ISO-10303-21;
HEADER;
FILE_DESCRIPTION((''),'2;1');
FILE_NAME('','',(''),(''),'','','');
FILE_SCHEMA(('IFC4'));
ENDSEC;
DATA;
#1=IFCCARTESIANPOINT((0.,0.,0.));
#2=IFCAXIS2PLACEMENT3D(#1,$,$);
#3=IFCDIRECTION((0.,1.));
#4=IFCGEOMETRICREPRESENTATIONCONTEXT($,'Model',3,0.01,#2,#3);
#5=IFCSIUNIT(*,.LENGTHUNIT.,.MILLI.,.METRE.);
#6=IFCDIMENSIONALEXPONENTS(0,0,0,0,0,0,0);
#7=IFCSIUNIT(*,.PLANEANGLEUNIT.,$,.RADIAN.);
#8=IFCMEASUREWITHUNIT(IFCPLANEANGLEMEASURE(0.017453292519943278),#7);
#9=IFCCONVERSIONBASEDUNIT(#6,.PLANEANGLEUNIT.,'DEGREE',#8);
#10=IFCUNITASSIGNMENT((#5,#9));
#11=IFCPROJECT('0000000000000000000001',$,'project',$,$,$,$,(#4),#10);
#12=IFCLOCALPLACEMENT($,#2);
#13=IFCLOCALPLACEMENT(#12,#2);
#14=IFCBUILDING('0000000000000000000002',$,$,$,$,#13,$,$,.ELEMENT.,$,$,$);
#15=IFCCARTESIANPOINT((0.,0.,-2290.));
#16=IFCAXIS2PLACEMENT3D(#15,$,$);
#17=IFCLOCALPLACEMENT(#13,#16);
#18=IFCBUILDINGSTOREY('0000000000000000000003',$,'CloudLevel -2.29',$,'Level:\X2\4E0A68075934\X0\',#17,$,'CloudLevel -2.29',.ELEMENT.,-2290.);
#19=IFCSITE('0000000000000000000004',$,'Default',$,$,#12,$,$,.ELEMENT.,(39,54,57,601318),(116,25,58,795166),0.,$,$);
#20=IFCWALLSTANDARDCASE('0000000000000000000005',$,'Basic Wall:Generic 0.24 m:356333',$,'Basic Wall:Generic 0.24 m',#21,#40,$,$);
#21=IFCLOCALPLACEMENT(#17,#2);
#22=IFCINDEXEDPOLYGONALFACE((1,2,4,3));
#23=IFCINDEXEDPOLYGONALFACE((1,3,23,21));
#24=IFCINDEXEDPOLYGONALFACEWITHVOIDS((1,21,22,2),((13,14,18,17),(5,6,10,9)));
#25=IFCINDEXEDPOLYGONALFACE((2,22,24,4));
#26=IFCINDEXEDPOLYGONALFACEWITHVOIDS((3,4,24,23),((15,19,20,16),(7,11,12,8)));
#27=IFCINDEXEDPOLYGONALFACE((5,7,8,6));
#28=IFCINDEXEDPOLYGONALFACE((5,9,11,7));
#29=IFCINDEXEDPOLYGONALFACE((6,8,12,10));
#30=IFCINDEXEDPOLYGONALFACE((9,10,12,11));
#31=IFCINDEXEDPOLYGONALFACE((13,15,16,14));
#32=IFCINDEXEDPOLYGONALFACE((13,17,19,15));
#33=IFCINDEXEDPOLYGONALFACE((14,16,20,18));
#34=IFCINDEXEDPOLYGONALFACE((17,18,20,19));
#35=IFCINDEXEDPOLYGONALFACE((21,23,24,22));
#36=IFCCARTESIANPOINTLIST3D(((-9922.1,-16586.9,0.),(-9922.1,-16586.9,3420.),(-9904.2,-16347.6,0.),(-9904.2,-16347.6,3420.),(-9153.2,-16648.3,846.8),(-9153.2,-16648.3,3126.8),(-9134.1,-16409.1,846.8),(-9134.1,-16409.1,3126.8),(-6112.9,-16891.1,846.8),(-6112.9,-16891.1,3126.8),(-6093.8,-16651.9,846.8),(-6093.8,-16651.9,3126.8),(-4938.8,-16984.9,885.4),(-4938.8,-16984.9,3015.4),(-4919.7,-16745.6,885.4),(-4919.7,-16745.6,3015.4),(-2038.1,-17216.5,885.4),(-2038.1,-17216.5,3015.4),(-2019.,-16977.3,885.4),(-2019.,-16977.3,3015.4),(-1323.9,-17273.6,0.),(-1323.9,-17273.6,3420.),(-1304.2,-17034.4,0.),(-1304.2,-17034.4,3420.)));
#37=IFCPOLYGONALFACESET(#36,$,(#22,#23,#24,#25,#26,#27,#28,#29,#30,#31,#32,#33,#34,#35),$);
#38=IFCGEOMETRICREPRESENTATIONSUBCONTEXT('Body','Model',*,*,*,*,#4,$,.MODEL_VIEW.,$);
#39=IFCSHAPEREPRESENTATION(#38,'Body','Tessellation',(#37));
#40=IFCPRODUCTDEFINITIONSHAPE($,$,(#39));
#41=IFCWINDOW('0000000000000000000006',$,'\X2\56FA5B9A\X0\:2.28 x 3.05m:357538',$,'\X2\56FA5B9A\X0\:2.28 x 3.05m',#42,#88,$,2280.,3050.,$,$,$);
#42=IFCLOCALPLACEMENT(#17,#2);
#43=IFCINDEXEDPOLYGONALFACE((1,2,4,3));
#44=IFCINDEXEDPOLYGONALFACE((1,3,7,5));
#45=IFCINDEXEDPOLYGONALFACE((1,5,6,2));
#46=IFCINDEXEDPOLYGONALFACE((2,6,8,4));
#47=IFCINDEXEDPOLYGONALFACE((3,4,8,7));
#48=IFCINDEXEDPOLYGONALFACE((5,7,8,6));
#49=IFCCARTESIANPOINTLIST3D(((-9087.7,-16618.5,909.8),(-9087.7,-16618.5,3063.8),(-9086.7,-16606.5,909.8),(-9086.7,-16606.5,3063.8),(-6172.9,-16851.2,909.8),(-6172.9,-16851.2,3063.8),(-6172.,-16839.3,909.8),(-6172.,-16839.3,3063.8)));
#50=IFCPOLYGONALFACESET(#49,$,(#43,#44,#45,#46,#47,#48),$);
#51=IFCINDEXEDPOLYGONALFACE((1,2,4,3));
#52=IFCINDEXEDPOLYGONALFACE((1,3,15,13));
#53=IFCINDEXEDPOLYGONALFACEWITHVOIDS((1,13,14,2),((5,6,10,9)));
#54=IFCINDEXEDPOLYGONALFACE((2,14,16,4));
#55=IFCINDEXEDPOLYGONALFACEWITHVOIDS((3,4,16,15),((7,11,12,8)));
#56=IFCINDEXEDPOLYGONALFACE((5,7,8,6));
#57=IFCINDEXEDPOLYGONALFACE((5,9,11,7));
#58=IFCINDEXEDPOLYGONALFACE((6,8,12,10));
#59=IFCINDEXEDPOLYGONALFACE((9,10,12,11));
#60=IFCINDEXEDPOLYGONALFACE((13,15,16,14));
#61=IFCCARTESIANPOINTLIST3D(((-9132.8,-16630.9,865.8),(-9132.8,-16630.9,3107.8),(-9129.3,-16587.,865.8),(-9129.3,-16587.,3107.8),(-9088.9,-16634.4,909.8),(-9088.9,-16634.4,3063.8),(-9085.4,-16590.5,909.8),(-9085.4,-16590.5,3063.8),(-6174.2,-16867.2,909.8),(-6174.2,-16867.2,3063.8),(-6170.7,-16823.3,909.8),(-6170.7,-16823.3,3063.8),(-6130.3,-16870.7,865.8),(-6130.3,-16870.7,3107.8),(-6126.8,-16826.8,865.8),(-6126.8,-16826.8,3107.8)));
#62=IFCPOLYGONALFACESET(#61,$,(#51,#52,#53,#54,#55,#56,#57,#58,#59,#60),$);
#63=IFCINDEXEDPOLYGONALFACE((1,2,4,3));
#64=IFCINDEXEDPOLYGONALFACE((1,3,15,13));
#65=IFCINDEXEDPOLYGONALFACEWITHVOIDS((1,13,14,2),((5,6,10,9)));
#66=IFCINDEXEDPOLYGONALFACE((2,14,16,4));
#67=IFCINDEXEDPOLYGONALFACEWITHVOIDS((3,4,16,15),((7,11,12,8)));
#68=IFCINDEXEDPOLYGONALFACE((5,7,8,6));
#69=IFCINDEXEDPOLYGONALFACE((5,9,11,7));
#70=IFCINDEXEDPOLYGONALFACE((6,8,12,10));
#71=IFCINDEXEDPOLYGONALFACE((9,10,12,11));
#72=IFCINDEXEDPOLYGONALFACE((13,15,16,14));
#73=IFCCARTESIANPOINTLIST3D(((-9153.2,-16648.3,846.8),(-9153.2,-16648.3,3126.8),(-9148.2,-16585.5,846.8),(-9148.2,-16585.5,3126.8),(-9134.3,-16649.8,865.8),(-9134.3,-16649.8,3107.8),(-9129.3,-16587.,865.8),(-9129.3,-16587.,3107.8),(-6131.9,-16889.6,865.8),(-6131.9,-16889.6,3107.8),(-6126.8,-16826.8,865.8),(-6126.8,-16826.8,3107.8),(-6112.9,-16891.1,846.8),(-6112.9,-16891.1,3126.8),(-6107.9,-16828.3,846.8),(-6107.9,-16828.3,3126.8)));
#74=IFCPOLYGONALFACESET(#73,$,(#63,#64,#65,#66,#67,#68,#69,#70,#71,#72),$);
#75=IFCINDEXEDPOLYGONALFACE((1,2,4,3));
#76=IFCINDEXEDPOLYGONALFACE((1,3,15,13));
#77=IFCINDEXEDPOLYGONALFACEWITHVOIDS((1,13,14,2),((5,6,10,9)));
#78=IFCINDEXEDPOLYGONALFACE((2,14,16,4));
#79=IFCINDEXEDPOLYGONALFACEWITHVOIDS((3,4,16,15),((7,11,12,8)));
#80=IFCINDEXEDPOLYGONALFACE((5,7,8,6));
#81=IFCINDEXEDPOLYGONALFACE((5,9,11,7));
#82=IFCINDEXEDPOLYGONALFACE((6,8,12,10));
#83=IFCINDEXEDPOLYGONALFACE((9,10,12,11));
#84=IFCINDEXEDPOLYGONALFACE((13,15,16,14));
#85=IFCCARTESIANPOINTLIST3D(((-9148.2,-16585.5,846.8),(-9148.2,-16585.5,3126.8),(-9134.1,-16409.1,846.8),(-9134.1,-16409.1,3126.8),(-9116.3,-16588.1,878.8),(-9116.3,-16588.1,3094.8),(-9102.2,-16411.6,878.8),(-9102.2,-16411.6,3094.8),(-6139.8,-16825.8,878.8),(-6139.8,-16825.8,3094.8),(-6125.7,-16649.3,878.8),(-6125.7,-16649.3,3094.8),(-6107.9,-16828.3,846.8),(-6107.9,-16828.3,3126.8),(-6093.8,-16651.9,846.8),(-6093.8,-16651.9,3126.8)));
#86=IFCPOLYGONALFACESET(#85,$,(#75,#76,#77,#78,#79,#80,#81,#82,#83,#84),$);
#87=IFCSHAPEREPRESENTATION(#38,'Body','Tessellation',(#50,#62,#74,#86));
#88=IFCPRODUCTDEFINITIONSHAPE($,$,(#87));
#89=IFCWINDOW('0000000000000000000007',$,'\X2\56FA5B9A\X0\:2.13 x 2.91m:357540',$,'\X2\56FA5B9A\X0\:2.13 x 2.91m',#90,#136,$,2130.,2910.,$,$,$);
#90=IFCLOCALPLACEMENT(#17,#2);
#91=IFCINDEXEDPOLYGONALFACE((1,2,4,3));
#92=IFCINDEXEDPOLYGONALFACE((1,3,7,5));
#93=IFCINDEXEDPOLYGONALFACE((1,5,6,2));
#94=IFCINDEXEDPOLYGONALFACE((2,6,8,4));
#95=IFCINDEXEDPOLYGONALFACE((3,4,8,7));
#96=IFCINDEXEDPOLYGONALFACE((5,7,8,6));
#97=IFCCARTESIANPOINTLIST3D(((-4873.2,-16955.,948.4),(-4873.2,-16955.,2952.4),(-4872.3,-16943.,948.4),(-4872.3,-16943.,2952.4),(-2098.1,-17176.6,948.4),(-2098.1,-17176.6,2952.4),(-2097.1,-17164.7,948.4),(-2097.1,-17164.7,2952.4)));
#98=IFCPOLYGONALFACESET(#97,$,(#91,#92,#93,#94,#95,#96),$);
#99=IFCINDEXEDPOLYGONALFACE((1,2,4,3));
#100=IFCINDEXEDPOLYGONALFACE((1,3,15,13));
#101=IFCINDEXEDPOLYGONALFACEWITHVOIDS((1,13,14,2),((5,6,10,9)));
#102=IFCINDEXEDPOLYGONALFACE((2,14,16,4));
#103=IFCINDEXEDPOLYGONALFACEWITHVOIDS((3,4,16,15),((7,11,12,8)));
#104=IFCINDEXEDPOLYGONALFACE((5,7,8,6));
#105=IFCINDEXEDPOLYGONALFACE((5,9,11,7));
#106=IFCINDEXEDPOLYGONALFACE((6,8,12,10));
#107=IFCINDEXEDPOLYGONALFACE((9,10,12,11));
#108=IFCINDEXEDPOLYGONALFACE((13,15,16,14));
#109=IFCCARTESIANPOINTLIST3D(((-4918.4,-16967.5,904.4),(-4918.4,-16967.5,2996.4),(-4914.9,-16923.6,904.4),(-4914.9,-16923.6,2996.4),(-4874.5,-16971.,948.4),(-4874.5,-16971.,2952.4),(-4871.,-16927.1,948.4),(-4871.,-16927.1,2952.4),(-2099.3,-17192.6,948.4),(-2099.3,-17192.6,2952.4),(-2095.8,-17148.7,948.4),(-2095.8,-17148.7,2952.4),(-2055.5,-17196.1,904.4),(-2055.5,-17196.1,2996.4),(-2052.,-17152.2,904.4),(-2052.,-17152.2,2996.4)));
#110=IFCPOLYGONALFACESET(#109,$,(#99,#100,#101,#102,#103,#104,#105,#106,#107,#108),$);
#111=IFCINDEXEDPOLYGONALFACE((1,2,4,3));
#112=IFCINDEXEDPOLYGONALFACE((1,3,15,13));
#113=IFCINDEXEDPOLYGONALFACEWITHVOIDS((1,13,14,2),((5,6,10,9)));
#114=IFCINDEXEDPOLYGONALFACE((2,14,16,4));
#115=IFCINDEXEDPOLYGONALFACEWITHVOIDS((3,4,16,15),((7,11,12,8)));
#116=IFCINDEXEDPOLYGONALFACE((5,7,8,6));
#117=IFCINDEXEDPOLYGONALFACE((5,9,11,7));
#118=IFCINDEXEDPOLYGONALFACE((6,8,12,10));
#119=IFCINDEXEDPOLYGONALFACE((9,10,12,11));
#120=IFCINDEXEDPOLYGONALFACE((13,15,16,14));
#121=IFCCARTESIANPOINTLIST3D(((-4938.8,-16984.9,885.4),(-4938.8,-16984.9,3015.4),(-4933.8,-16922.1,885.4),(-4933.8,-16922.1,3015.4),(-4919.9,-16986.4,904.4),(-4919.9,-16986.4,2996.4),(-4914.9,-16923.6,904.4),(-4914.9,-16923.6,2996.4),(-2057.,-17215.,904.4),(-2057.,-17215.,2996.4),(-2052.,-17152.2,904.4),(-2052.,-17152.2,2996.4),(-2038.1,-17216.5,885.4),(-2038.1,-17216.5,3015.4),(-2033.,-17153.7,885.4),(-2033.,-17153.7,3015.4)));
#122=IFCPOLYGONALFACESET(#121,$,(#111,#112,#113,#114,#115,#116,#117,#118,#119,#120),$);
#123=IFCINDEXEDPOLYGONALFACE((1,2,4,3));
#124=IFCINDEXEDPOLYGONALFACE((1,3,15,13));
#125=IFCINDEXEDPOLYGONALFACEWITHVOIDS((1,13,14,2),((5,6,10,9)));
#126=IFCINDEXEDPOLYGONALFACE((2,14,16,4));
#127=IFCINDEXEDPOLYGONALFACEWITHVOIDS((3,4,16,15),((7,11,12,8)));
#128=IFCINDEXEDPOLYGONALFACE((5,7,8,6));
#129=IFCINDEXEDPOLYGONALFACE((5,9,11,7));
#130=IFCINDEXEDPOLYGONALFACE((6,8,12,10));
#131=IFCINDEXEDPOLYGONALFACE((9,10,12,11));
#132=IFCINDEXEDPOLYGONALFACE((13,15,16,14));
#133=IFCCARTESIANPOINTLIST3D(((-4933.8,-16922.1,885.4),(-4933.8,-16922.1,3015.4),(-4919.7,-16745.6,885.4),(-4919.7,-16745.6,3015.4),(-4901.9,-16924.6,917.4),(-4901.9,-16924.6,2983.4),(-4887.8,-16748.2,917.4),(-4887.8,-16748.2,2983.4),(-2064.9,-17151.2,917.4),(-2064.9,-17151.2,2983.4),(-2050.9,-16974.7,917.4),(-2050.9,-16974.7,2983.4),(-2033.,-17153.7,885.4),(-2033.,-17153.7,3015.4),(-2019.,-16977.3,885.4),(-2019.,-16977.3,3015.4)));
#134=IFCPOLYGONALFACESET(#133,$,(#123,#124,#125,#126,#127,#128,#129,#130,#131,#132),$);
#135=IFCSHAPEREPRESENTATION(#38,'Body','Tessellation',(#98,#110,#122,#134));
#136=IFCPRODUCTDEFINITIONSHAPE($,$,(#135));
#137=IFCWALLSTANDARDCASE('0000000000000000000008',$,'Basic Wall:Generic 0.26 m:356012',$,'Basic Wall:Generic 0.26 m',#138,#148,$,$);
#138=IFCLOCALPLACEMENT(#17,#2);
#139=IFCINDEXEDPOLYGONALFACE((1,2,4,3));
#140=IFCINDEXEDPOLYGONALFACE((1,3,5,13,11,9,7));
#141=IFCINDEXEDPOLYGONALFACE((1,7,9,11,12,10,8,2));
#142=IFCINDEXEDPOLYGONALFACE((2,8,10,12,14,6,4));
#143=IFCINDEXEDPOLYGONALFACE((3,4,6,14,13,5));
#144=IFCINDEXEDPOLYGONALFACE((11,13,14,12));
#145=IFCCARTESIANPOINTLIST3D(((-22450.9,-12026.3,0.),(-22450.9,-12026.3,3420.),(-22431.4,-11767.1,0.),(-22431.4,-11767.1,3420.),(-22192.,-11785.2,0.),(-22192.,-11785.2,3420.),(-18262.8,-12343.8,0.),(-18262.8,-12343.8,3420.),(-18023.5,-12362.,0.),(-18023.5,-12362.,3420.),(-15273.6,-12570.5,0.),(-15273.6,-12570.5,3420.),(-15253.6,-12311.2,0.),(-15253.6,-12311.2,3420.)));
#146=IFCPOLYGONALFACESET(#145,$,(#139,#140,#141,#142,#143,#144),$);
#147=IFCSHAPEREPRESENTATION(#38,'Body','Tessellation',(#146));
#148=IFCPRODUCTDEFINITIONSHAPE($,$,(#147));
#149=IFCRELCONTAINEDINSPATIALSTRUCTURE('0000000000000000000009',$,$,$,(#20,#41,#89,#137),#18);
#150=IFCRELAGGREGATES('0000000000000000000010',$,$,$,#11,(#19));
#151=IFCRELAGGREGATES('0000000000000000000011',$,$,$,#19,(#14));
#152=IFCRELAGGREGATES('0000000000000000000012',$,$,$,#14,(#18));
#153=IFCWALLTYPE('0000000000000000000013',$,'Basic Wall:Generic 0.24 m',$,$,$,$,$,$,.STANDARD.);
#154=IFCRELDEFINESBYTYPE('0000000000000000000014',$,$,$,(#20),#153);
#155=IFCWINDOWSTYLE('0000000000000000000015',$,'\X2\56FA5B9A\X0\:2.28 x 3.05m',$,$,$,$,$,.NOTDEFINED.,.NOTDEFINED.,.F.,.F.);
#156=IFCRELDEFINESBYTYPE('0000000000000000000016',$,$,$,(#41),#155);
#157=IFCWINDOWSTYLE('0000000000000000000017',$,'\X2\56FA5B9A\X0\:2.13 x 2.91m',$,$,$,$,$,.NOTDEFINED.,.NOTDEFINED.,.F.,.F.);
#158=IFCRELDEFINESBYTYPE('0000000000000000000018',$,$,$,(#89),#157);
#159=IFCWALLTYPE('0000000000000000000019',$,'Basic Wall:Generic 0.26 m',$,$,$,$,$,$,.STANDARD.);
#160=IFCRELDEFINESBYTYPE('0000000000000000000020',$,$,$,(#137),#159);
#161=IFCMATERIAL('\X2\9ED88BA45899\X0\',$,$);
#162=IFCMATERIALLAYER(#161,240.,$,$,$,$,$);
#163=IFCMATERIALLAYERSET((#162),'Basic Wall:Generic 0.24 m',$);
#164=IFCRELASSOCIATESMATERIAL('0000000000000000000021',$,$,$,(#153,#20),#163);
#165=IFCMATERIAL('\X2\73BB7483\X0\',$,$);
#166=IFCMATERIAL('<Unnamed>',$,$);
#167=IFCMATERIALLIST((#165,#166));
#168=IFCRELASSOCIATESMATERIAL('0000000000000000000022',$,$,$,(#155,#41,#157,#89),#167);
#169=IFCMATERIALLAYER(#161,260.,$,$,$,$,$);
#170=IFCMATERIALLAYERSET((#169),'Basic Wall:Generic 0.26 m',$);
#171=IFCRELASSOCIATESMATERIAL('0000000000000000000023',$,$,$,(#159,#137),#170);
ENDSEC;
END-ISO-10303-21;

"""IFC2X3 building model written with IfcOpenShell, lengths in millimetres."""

from ifc_helpers import new_model, entity, si_unit, converted_unit, direction, frame, frame_2d, origin, place, context, subcontext, project, spatial, polyline, rectangle, outline, extrude, source, transform, mapped, material, material_list, layer, layer_set, layer_usage, type_object, type_shapes, element, fill, save


model = new_model("IFC2X3")

# Units and contexts
model_context = context("Model", 3, precision=0.01, world=origin(), true_north=direction((0.0, 1.0)))
body_context = subcontext(model_context, "Body", "Model", "MODEL_VIEW")
ifc_project = project(units=[si_unit("LENGTHUNIT", "METRE", prefix="MILLI"), converted_unit("PLANEANGLEUNIT", "DEGREE", entity("IfcPlaneAngleMeasure", 0.017453292519943278), si_unit("PLANEANGLEUNIT", "RADIAN"), dimensions=[0, 0, 0, 0, 0, 0, 0])], contexts=[model_context])

# Site, building, storey
site_placement = place(None, origin())
site = spatial("IfcSite", under=ifc_project, at=site_placement, Name="Default", CompositionType="ELEMENT", RefLatitude=(39, 54, 57, 601318), RefLongitude=(116, 25, 58, 795166), RefElevation=0.0)
building_placement = place(site_placement, origin())
building = spatial("IfcBuilding", under=site, at=building_placement, CompositionType="ELEMENT")
storey_placement = place(building_placement, frame((0.0, 0.0, -2290.0)))
storey = spatial("IfcBuildingStorey", under=building, at=storey_placement, Name="CloudLevel -2.29", ObjectType="Level:上标头", LongName="CloudLevel -2.29", CompositionType="ELEMENT", Elevation=-2290.0)

# Shared definitions
ifc_material_1 = material(Name="默认墙")
ifc_layer_1 = layer(ifc_material_1, 240.0)
ifc_layer_set_1 = layer_set([ifc_layer_1], Name="Basic Wall:Generic 0.24 m")
ifc_layer_usage_1 = layer_usage(ifc_layer_set_1, "AXIS2", "NEGATIVE", 120.0)
wall_type_1 = type_object("IfcWallType", Name="Basic Wall:Generic 0.24 m", PredefinedType="STANDARD", material=ifc_layer_set_1)

# Shared definitions
ifc_material_2 = material(Name="玻璃")
ifc_material_3 = material(Name="<Unnamed>")
ifc_material_list = material_list([ifc_material_2, ifc_material_3])

# Wall, openings, windows
wall_1_placement = place(storey_placement, frame((-9913.7, -16467.2, 0.0), z_axis=(0.0, 0.0, 1.0), x_axis=(0.996827, -0.079604, 0.0)))
wall_1 = element("IfcWallStandardCase", 1, at=wall_1_placement, inside=storey, type_object=wall_type_1, material=ifc_layer_usage_1, Name="Basic Wall:Generic 0.24 m:356333", ObjectType="Basic Wall:Generic 0.24 m", context=body_context, shape_type="SweptSolid", body=[
    extrude(outline(polyline([(8626.7, -120.0), (8627.3, 120.0), (8387.3, 120.0), (240.0, 120.0), (0.0, 120.0), (1.2, -120.0), (8626.7, -120.0)])), origin(), (0.0, 0.0, 1.0), 3420.0),
])
opening_1_placement = place(wall_1_placement, frame((3822.5, 120.0, 846.8)))
opening_1 = element("IfcOpeningElement", 2, at=opening_1_placement, cuts=wall_1, ObjectType="Opening", context=body_context, shape_type="SweptSolid", body=[
    extrude(rectangle(XDim=2280.0, YDim=3050.0, at=frame_2d((1140.0, 1525.0), x_axis=(1.0, 0.0))), frame((0.0, 0.0, 0.0), z_axis=(0.0, -1.0, 0.0), x_axis=(0.0, 0.0, 1.0)), (0.0, 0.0, 1.0), 240.0),
])
opening_2_placement = place(wall_1_placement, frame((7910.3, 120.0, 885.4)))
opening_2 = element("IfcOpeningElement", 3, at=opening_2_placement, cuts=wall_1, ObjectType="Opening", context=body_context, shape_type="SweptSolid", body=[
    extrude(rectangle(XDim=2130.0, YDim=2910.0, at=frame_2d((1065.0, 1455.0), x_axis=(1.0, 0.0))), frame((0.0, 0.0, 0.0), z_axis=(0.0, -1.0, 0.0), x_axis=(0.0, 0.0, 1.0)), (0.0, 0.0, 1.0), 240.0),
])
window_style_1 = type_object("IfcWindowStyle", Name="固定:2.28 x 3.05m", ConstructionType="NOTDEFINED", OperationType="NOTDEFINED", ParameterTakesPrecedence=False, Sizeable=False, material=ifc_material_list)
shared_shape_1 = source(origin(), body_context, "Body", "SweptSolid", [
    extrude(rectangle(XDim=2924.0, YDim=12.0, at=frame_2d((0.0, 0.0), x_axis=(1.0, 0.0))), frame((1525.0, 225.0, 63.0), z_axis=(0.0, 0.0, 1.0), x_axis=(-1.0, 0.0, 0.0)), (0.0, 0.0, 1.0), 2154.0),
    extrude(outline(polyline([(-1506.0, -1121.0), (1506.0, -1121.0), (1506.0, 1121.0), (-1506.0, 1121.0), (-1506.0, -1121.0)]), holes=[polyline([(-1462.0, -1077.0), (-1462.0, 1077.0), (1462.0, 1077.0), (1462.0, -1077.0), (-1462.0, -1077.0)])]), frame((1525.0, 247.0, 1140.0), z_axis=(0.0, -1.0, 0.0), x_axis=(-1.0, 0.0, 0.0)), (0.0, 0.0, 1.0), 44.0),
    extrude(outline(polyline([(-1525.0, -1140.0), (1525.0, -1140.0), (1525.0, 1140.0), (-1525.0, 1140.0), (-1525.0, -1140.0)]), holes=[polyline([(-1506.0, -1121.0), (-1506.0, 1121.0), (1506.0, 1121.0), (1506.0, -1121.0), (-1506.0, -1121.0)])]), frame((1525.0, 266.0, 1140.0), z_axis=(0.0, -1.0, 0.0), x_axis=(-1.0, 0.0, 0.0)), (0.0, 0.0, 1.0), 63.0),
    extrude(outline(polyline([(-1525.0, -1140.0), (1525.0, -1140.0), (1525.0, 1140.0), (-1525.0, 1140.0), (-1525.0, -1140.0)]), holes=[polyline([(-1493.0, -1108.0), (-1493.0, 1108.0), (1493.0, 1108.0), (1493.0, -1108.0), (-1493.0, -1108.0)])]), frame((1525.0, 203.0, 1140.0), z_axis=(0.0, -1.0, 0.0), x_axis=(-1.0, 0.0, 0.0)), (0.0, 0.0, 1.0), 177.0),
])
type_shapes(window_style_1, [shared_shape_1])
window_1_placement = place(opening_1_placement, frame((0.0, 26.0, 0.0), z_axis=(0.0, 0.0, 1.0), x_axis=(-1.0, 0.0, 0.0)))
window_1 = element("IfcWindow", 4, at=window_1_placement, inside=storey, type_object=window_style_1, material=ifc_material_list, Name="固定:2.28 x 3.05m:357538", ObjectType="固定:2.28 x 3.05m", OverallHeight=2280.0, OverallWidth=3050.0, context=body_context, shape_type="MappedRepresentation", body=[
    mapped(shared_shape_1, transform((0.0, 0.0, 0.0), scale=1.0)),
])
fill(opening_1, window_1)
window_style_2 = type_object("IfcWindowStyle", Name="固定:2.13 x 2.91m", ConstructionType="NOTDEFINED", OperationType="NOTDEFINED", ParameterTakesPrecedence=False, Sizeable=False, material=ifc_material_list)
shared_shape_2 = source(origin(), body_context, "Body", "SweptSolid", [
    extrude(rectangle(XDim=2784.0, YDim=12.0, at=frame_2d((0.0, 0.0), x_axis=(1.0, 0.0))), frame((1455.0, 225.0, 63.0), z_axis=(0.0, 0.0, 1.0), x_axis=(-1.0, 0.0, 0.0)), (0.0, 0.0, 1.0), 2004.0),
    extrude(outline(polyline([(-1436.0, -1046.0), (1436.0, -1046.0), (1436.0, 1046.0), (-1436.0, 1046.0), (-1436.0, -1046.0)]), holes=[polyline([(-1392.0, -1002.0), (-1392.0, 1002.0), (1392.0, 1002.0), (1392.0, -1002.0), (-1392.0, -1002.0)])]), frame((1455.0, 247.0, 1065.0), z_axis=(0.0, -1.0, 0.0), x_axis=(-1.0, 0.0, 0.0)), (0.0, 0.0, 1.0), 44.0),
    extrude(outline(polyline([(-1455.0, -1065.0), (1455.0, -1065.0), (1455.0, 1065.0), (-1455.0, 1065.0), (-1455.0, -1065.0)]), holes=[polyline([(-1436.0, -1046.0), (-1436.0, 1046.0), (1436.0, 1046.0), (1436.0, -1046.0), (-1436.0, -1046.0)])]), frame((1455.0, 266.0, 1065.0), z_axis=(0.0, -1.0, 0.0), x_axis=(-1.0, 0.0, 0.0)), (0.0, 0.0, 1.0), 63.0),
    extrude(outline(polyline([(-1455.0, -1065.0), (1455.0, -1065.0), (1455.0, 1065.0), (-1455.0, 1065.0), (-1455.0, -1065.0)]), holes=[polyline([(-1423.0, -1033.0), (-1423.0, 1033.0), (1423.0, 1033.0), (1423.0, -1033.0), (-1423.0, -1033.0)])]), frame((1455.0, 203.0, 1065.0), z_axis=(0.0, -1.0, 0.0), x_axis=(-1.0, 0.0, 0.0)), (0.0, 0.0, 1.0), 177.0),
])
type_shapes(window_style_2, [shared_shape_2])
window_2_placement = place(opening_2_placement, frame((0.0, 26.0, 0.0), z_axis=(0.0, 0.0, 1.0), x_axis=(-1.0, 0.0, 0.0)))
window_2 = element("IfcWindow", 5, at=window_2_placement, inside=storey, type_object=window_style_2, material=ifc_material_list, Name="固定:2.13 x 2.91m:357540", ObjectType="固定:2.13 x 2.91m", OverallHeight=2130.0, OverallWidth=2910.0, context=body_context, shape_type="MappedRepresentation", body=[
    mapped(shared_shape_2, transform((0.0, 0.0, 0.0), scale=1.0)),
])
fill(opening_2, window_2)

# Wall
ifc_layer_2 = layer(ifc_material_1, 260.0)
ifc_layer_set_2 = layer_set([ifc_layer_2], Name="Basic Wall:Generic 0.26 m")
ifc_layer_usage_2 = layer_usage(ifc_layer_set_2, "AXIS2", "NEGATIVE", 130.0)
wall_type_2 = type_object("IfcWallType", Name="Basic Wall:Generic 0.26 m", PredefinedType="STANDARD", material=ifc_layer_set_2)
wall_2_placement = place(storey_placement, frame((-15263.4, -12440.9, 0.0), z_axis=(0.0, 0.0, 1.0), x_axis=(-0.997139, 0.075595, 0.0)))
element("IfcWallStandardCase", 6, at=wall_2_placement, inside=storey, type_object=wall_type_2, material=ifc_layer_usage_2, Name="Basic Wall:Generic 0.26 m:356012", ObjectType="Basic Wall:Generic 0.26 m", context=body_context, shape_type="SweptSolid", body=[
    extrude(outline(polyline([(7198.4, -130.0), (7198.3, 130.0), (2998.1, 130.0), (2758.1, 130.0), (0.3, 130.0), (0.0, -130.0), (6958.4, -130.0), (7198.4, -130.0)])), origin(), (0.0, 0.0, 1.0), 3420.0),
])

save(model, "model.ifc")
